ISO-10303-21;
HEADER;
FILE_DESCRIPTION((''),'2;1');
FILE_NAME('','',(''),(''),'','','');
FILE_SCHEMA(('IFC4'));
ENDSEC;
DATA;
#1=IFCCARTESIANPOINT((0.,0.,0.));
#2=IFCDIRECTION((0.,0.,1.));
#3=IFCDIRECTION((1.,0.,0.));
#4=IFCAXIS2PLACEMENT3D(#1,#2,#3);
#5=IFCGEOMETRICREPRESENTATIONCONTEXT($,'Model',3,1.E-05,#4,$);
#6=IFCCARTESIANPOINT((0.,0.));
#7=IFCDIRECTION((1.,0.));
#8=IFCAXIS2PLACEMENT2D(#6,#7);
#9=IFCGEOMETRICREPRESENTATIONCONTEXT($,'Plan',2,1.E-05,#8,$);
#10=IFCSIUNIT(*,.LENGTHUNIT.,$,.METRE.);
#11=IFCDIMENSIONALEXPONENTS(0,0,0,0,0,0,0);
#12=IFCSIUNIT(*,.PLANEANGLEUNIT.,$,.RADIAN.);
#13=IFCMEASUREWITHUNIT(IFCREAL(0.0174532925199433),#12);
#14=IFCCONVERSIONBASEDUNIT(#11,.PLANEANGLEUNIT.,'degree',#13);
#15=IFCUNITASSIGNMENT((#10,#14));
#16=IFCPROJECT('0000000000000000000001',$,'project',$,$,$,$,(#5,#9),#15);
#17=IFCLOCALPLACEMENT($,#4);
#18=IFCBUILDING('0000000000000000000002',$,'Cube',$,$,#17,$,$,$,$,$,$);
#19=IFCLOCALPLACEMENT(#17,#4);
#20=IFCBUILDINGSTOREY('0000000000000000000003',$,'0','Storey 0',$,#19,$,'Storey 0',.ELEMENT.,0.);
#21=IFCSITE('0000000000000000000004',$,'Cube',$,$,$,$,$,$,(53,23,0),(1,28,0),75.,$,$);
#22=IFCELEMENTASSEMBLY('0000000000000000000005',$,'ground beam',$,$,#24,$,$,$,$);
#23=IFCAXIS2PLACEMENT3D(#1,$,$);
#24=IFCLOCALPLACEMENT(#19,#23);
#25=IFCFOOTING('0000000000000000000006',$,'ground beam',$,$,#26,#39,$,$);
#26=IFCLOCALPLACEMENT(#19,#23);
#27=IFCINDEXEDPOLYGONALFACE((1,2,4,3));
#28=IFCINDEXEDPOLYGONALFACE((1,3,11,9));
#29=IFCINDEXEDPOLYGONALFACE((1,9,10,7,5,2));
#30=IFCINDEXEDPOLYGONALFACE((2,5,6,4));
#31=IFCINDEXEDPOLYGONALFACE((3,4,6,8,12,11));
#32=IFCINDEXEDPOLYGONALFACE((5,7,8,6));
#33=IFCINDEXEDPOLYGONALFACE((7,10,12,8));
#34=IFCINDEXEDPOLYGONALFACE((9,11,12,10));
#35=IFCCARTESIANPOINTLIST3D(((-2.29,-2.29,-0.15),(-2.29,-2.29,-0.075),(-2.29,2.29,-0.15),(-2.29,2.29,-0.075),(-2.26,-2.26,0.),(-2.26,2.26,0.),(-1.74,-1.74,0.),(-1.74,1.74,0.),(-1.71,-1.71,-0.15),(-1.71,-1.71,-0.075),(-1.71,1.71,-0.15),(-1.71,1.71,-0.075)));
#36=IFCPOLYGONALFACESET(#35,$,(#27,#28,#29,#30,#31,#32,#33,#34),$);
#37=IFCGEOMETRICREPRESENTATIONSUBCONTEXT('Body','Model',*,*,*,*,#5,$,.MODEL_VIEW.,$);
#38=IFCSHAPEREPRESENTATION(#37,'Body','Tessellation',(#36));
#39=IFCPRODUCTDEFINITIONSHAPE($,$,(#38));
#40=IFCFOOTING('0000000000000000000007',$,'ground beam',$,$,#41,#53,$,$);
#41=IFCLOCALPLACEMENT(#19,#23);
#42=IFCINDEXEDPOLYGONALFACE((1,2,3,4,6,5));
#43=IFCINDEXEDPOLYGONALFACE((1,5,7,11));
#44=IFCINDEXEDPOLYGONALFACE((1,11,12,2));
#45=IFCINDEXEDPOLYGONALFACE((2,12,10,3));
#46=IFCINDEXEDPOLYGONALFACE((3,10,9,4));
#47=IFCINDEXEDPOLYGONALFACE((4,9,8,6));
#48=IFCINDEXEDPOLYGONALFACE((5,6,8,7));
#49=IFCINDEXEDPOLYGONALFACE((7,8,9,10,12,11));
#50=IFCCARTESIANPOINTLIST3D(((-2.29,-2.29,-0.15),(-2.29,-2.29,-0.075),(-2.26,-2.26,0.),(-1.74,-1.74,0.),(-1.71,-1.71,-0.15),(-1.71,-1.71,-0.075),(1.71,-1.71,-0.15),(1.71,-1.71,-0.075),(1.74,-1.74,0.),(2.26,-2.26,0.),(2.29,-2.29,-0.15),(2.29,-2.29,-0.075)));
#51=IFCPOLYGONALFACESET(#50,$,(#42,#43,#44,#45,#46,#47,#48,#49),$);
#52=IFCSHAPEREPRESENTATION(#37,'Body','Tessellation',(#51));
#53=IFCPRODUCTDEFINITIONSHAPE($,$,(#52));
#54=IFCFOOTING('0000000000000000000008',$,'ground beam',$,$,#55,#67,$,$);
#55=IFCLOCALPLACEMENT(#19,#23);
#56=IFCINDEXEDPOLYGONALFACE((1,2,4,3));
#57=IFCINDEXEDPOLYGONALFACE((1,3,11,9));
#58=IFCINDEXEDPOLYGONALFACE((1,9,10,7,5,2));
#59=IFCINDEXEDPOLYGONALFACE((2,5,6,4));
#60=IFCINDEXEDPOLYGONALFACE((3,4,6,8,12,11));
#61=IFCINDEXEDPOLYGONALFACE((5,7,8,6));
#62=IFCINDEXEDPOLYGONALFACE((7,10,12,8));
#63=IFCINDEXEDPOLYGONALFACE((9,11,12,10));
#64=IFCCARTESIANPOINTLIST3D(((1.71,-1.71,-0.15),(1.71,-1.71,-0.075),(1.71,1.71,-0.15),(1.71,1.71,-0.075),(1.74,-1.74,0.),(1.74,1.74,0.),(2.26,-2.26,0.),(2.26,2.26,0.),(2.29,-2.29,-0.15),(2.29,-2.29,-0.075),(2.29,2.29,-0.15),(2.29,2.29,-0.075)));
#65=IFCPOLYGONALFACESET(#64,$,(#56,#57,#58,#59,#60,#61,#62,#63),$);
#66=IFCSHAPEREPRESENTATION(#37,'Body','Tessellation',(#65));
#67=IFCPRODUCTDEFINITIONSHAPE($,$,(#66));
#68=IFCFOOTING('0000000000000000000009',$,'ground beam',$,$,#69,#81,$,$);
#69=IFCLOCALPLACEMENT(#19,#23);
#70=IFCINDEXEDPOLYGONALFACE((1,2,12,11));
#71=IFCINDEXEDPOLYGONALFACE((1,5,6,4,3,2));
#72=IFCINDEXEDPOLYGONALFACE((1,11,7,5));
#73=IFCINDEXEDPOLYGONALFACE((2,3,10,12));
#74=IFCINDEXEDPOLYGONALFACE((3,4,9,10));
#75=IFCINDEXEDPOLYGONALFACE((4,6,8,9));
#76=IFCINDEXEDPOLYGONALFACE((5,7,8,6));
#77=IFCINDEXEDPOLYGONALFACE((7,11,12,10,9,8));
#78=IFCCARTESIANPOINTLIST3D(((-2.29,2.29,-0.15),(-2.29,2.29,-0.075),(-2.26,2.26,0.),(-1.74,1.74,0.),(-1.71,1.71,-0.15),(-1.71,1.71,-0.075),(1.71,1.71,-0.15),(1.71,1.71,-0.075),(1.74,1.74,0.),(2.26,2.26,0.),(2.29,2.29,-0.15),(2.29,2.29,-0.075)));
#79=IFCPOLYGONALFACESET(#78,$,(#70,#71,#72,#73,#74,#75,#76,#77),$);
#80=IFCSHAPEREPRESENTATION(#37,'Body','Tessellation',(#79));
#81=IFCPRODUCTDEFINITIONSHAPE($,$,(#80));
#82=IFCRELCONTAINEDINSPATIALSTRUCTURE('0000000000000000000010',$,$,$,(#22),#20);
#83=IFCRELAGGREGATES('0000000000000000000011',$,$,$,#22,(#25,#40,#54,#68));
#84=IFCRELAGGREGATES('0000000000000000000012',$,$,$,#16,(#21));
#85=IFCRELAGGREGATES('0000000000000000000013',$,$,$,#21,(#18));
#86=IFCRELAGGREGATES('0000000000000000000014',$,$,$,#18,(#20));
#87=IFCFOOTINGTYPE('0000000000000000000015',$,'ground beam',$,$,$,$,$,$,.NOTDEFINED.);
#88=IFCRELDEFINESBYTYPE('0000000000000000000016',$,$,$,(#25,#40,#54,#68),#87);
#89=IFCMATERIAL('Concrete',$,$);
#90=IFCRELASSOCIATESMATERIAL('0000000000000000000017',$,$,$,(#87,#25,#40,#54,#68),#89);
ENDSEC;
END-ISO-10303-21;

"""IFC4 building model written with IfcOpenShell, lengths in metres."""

from ifc_helpers import new_model, entity, si_unit, converted_unit, frame, origin_with_axes, origin_2d_with_axis, place, context, subcontext, project, spatial, polyline, outline, extrude, clip, halfspace, material, material_profile, profile_set, profile_usage, type_object, element, aggregate, save


model = new_model("IFC4")

# Units and contexts
model_context = context("Model", 3, precision=1e-05, world=origin_with_axes())
plan_context = context("Plan", 2, precision=1e-05, world=origin_2d_with_axis())
body_context = subcontext(model_context, "Body", "Model", "MODEL_VIEW")
ifc_project = project(units=[si_unit("LENGTHUNIT", "METRE"), converted_unit("PLANEANGLEUNIT", "degree", entity("IfcReal", 0.0174532925199433), si_unit("PLANEANGLEUNIT", "RADIAN"), dimensions=[0, 0, 0, 0, 0, 0, 0])], contexts=[model_context, plan_context])

# Site, building, storey
site = spatial("IfcSite", under=ifc_project, Name="Cube", RefLatitude=(53, 23, 0), RefLongitude=(1, 28, 0), RefElevation=75.0)
building_placement = place(None, origin_with_axes())
building = spatial("IfcBuilding", under=site, at=building_placement, Name="Cube")
storey_placement = place(building_placement, origin_with_axes())
storey = spatial("IfcBuildingStorey", under=building, at=storey_placement, Name="0", Description="Storey 0", LongName="Storey 0", CompositionType="ELEMENT", Elevation=0.0)

# Element assembly, footings
assembly_placement = place(storey_placement, origin_with_axes())
assembly = element("IfcElementAssembly", 1, at=assembly_placement, inside=storey, Name="ground beam")
ifc_material = material(Name="Concrete")
ifc_material_profile = material_profile(ifc_material, outline(polyline([(-0.26, 0.0), (-0.29, -0.075), (-0.29, -0.15), (0.29, -0.15), (0.29, -0.075), (0.26, 0.0), (-0.26, 0.0)])))
ifc_profile_set = profile_set([ifc_material_profile])
ifc_profile_usage_1 = profile_usage(ifc_profile_set)
footing_type = type_object("IfcFootingType", Name="ground beam", PredefinedType="NOTDEFINED", material=ifc_profile_set)
footing_1_placement = place(assembly_placement, frame((-2.0, -3.0, 0.0), z_axis=(0.0, 1.0, 0.0), x_axis=(-1.0, 0.0, 0.0)))
footing_1 = element("IfcFooting", 2, at=footing_1_placement, type_object=footing_type, material=ifc_profile_usage_1, Name="ground beam", context=body_context, shape_type="Clipping", body=[
    clip(clip(extrude(outline(polyline([(-0.26, 0.0), (-0.29, -0.075), (-0.29, -0.15), (0.29, -0.15), (0.29, -0.075), (0.26, 0.0), (-0.26, 0.0)])), origin_with_axes(), (0.0, 0.0, 1.0), 6.0), halfspace(frame((0.0, 0.0, 1.0), z_axis=(-0.707107, 0.0, -0.707107), x_axis=(0.0, 1.0, 0.0)), False)), halfspace(frame((0.0, 0.0, 5.0), z_axis=(-0.707107, 0.0, 0.707107), x_axis=(0.0, 1.0, 0.0)), False)),
])
ifc_profile_usage_2 = profile_usage(ifc_profile_set)
footing_2_placement = place(assembly_placement, frame((3.0, -2.0, 0.0), z_axis=(-1.0, 0.0, 0.0), x_axis=(0.0, -1.0, 0.0)))
footing_2 = element("IfcFooting", 3, at=footing_2_placement, type_object=footing_type, material=ifc_profile_usage_2, Name="ground beam", context=body_context, shape_type="Clipping", body=[
    clip(clip(extrude(outline(polyline([(-0.26, 0.0), (-0.29, -0.075), (-0.29, -0.15), (0.29, -0.15), (0.29, -0.075), (0.26, 0.0), (-0.26, 0.0)])), origin_with_axes(), (0.0, 0.0, 1.0), 6.0), halfspace(frame((0.0, 0.0, 1.0), z_axis=(-0.707107, 0.0, -0.707107), x_axis=(0.0, 1.0, 0.0)), False)), halfspace(frame((0.0, 0.0, 5.0), z_axis=(-0.707107, 0.0, 0.707107), x_axis=(0.0, 1.0, 0.0)), False)),
])
ifc_profile_usage_3 = profile_usage(ifc_profile_set)
footing_3_placement = place(assembly_placement, frame((2.0, 3.0, 0.0), z_axis=(0.0, -1.0, 0.0), x_axis=(1.0, 0.0, 0.0)))
footing_3 = element("IfcFooting", 4, at=footing_3_placement, type_object=footing_type, material=ifc_profile_usage_3, Name="ground beam", context=body_context, shape_type="Clipping", body=[
    clip(clip(extrude(outline(polyline([(-0.26, 0.0), (-0.29, -0.075), (-0.29, -0.15), (0.29, -0.15), (0.29, -0.075), (0.26, 0.0), (-0.26, 0.0)])), origin_with_axes(), (0.0, 0.0, 1.0), 6.0), halfspace(frame((0.0, 0.0, 1.0), z_axis=(-0.707107, 0.0, -0.707107), x_axis=(0.0, 1.0, 0.0)), False)), halfspace(frame((0.0, 0.0, 5.0), z_axis=(-0.707107, 0.0, 0.707107), x_axis=(0.0, 1.0, 0.0)), False)),
])
ifc_profile_usage_4 = profile_usage(ifc_profile_set)
footing_4_placement = place(assembly_placement, frame((-3.0, 2.0, 0.0), z_axis=(1.0, 0.0, 0.0), x_axis=(0.0, 1.0, 0.0)))
footing_4 = element("IfcFooting", 5, at=footing_4_placement, type_object=footing_type, material=ifc_profile_usage_4, Name="ground beam", context=body_context, shape_type="Clipping", body=[
    clip(clip(extrude(outline(polyline([(-0.26, 0.0), (-0.29, -0.075), (-0.29, -0.15), (0.29, -0.15), (0.29, -0.075), (0.26, 0.0), (-0.26, 0.0)])), origin_with_axes(), (0.0, 0.0, 1.0), 6.0), halfspace(frame((0.0, 0.0, 1.0), z_axis=(-0.707107, 0.0, -0.707107), x_axis=(0.0, 1.0, 0.0)), False)), halfspace(frame((0.0, 0.0, 5.0), z_axis=(-0.707107, 0.0, 0.707107), x_axis=(0.0, 1.0, 0.0)), False)),
])
aggregate(assembly, [footing_1, footing_2, footing_3, footing_4])

save(model, "model.ifc")
